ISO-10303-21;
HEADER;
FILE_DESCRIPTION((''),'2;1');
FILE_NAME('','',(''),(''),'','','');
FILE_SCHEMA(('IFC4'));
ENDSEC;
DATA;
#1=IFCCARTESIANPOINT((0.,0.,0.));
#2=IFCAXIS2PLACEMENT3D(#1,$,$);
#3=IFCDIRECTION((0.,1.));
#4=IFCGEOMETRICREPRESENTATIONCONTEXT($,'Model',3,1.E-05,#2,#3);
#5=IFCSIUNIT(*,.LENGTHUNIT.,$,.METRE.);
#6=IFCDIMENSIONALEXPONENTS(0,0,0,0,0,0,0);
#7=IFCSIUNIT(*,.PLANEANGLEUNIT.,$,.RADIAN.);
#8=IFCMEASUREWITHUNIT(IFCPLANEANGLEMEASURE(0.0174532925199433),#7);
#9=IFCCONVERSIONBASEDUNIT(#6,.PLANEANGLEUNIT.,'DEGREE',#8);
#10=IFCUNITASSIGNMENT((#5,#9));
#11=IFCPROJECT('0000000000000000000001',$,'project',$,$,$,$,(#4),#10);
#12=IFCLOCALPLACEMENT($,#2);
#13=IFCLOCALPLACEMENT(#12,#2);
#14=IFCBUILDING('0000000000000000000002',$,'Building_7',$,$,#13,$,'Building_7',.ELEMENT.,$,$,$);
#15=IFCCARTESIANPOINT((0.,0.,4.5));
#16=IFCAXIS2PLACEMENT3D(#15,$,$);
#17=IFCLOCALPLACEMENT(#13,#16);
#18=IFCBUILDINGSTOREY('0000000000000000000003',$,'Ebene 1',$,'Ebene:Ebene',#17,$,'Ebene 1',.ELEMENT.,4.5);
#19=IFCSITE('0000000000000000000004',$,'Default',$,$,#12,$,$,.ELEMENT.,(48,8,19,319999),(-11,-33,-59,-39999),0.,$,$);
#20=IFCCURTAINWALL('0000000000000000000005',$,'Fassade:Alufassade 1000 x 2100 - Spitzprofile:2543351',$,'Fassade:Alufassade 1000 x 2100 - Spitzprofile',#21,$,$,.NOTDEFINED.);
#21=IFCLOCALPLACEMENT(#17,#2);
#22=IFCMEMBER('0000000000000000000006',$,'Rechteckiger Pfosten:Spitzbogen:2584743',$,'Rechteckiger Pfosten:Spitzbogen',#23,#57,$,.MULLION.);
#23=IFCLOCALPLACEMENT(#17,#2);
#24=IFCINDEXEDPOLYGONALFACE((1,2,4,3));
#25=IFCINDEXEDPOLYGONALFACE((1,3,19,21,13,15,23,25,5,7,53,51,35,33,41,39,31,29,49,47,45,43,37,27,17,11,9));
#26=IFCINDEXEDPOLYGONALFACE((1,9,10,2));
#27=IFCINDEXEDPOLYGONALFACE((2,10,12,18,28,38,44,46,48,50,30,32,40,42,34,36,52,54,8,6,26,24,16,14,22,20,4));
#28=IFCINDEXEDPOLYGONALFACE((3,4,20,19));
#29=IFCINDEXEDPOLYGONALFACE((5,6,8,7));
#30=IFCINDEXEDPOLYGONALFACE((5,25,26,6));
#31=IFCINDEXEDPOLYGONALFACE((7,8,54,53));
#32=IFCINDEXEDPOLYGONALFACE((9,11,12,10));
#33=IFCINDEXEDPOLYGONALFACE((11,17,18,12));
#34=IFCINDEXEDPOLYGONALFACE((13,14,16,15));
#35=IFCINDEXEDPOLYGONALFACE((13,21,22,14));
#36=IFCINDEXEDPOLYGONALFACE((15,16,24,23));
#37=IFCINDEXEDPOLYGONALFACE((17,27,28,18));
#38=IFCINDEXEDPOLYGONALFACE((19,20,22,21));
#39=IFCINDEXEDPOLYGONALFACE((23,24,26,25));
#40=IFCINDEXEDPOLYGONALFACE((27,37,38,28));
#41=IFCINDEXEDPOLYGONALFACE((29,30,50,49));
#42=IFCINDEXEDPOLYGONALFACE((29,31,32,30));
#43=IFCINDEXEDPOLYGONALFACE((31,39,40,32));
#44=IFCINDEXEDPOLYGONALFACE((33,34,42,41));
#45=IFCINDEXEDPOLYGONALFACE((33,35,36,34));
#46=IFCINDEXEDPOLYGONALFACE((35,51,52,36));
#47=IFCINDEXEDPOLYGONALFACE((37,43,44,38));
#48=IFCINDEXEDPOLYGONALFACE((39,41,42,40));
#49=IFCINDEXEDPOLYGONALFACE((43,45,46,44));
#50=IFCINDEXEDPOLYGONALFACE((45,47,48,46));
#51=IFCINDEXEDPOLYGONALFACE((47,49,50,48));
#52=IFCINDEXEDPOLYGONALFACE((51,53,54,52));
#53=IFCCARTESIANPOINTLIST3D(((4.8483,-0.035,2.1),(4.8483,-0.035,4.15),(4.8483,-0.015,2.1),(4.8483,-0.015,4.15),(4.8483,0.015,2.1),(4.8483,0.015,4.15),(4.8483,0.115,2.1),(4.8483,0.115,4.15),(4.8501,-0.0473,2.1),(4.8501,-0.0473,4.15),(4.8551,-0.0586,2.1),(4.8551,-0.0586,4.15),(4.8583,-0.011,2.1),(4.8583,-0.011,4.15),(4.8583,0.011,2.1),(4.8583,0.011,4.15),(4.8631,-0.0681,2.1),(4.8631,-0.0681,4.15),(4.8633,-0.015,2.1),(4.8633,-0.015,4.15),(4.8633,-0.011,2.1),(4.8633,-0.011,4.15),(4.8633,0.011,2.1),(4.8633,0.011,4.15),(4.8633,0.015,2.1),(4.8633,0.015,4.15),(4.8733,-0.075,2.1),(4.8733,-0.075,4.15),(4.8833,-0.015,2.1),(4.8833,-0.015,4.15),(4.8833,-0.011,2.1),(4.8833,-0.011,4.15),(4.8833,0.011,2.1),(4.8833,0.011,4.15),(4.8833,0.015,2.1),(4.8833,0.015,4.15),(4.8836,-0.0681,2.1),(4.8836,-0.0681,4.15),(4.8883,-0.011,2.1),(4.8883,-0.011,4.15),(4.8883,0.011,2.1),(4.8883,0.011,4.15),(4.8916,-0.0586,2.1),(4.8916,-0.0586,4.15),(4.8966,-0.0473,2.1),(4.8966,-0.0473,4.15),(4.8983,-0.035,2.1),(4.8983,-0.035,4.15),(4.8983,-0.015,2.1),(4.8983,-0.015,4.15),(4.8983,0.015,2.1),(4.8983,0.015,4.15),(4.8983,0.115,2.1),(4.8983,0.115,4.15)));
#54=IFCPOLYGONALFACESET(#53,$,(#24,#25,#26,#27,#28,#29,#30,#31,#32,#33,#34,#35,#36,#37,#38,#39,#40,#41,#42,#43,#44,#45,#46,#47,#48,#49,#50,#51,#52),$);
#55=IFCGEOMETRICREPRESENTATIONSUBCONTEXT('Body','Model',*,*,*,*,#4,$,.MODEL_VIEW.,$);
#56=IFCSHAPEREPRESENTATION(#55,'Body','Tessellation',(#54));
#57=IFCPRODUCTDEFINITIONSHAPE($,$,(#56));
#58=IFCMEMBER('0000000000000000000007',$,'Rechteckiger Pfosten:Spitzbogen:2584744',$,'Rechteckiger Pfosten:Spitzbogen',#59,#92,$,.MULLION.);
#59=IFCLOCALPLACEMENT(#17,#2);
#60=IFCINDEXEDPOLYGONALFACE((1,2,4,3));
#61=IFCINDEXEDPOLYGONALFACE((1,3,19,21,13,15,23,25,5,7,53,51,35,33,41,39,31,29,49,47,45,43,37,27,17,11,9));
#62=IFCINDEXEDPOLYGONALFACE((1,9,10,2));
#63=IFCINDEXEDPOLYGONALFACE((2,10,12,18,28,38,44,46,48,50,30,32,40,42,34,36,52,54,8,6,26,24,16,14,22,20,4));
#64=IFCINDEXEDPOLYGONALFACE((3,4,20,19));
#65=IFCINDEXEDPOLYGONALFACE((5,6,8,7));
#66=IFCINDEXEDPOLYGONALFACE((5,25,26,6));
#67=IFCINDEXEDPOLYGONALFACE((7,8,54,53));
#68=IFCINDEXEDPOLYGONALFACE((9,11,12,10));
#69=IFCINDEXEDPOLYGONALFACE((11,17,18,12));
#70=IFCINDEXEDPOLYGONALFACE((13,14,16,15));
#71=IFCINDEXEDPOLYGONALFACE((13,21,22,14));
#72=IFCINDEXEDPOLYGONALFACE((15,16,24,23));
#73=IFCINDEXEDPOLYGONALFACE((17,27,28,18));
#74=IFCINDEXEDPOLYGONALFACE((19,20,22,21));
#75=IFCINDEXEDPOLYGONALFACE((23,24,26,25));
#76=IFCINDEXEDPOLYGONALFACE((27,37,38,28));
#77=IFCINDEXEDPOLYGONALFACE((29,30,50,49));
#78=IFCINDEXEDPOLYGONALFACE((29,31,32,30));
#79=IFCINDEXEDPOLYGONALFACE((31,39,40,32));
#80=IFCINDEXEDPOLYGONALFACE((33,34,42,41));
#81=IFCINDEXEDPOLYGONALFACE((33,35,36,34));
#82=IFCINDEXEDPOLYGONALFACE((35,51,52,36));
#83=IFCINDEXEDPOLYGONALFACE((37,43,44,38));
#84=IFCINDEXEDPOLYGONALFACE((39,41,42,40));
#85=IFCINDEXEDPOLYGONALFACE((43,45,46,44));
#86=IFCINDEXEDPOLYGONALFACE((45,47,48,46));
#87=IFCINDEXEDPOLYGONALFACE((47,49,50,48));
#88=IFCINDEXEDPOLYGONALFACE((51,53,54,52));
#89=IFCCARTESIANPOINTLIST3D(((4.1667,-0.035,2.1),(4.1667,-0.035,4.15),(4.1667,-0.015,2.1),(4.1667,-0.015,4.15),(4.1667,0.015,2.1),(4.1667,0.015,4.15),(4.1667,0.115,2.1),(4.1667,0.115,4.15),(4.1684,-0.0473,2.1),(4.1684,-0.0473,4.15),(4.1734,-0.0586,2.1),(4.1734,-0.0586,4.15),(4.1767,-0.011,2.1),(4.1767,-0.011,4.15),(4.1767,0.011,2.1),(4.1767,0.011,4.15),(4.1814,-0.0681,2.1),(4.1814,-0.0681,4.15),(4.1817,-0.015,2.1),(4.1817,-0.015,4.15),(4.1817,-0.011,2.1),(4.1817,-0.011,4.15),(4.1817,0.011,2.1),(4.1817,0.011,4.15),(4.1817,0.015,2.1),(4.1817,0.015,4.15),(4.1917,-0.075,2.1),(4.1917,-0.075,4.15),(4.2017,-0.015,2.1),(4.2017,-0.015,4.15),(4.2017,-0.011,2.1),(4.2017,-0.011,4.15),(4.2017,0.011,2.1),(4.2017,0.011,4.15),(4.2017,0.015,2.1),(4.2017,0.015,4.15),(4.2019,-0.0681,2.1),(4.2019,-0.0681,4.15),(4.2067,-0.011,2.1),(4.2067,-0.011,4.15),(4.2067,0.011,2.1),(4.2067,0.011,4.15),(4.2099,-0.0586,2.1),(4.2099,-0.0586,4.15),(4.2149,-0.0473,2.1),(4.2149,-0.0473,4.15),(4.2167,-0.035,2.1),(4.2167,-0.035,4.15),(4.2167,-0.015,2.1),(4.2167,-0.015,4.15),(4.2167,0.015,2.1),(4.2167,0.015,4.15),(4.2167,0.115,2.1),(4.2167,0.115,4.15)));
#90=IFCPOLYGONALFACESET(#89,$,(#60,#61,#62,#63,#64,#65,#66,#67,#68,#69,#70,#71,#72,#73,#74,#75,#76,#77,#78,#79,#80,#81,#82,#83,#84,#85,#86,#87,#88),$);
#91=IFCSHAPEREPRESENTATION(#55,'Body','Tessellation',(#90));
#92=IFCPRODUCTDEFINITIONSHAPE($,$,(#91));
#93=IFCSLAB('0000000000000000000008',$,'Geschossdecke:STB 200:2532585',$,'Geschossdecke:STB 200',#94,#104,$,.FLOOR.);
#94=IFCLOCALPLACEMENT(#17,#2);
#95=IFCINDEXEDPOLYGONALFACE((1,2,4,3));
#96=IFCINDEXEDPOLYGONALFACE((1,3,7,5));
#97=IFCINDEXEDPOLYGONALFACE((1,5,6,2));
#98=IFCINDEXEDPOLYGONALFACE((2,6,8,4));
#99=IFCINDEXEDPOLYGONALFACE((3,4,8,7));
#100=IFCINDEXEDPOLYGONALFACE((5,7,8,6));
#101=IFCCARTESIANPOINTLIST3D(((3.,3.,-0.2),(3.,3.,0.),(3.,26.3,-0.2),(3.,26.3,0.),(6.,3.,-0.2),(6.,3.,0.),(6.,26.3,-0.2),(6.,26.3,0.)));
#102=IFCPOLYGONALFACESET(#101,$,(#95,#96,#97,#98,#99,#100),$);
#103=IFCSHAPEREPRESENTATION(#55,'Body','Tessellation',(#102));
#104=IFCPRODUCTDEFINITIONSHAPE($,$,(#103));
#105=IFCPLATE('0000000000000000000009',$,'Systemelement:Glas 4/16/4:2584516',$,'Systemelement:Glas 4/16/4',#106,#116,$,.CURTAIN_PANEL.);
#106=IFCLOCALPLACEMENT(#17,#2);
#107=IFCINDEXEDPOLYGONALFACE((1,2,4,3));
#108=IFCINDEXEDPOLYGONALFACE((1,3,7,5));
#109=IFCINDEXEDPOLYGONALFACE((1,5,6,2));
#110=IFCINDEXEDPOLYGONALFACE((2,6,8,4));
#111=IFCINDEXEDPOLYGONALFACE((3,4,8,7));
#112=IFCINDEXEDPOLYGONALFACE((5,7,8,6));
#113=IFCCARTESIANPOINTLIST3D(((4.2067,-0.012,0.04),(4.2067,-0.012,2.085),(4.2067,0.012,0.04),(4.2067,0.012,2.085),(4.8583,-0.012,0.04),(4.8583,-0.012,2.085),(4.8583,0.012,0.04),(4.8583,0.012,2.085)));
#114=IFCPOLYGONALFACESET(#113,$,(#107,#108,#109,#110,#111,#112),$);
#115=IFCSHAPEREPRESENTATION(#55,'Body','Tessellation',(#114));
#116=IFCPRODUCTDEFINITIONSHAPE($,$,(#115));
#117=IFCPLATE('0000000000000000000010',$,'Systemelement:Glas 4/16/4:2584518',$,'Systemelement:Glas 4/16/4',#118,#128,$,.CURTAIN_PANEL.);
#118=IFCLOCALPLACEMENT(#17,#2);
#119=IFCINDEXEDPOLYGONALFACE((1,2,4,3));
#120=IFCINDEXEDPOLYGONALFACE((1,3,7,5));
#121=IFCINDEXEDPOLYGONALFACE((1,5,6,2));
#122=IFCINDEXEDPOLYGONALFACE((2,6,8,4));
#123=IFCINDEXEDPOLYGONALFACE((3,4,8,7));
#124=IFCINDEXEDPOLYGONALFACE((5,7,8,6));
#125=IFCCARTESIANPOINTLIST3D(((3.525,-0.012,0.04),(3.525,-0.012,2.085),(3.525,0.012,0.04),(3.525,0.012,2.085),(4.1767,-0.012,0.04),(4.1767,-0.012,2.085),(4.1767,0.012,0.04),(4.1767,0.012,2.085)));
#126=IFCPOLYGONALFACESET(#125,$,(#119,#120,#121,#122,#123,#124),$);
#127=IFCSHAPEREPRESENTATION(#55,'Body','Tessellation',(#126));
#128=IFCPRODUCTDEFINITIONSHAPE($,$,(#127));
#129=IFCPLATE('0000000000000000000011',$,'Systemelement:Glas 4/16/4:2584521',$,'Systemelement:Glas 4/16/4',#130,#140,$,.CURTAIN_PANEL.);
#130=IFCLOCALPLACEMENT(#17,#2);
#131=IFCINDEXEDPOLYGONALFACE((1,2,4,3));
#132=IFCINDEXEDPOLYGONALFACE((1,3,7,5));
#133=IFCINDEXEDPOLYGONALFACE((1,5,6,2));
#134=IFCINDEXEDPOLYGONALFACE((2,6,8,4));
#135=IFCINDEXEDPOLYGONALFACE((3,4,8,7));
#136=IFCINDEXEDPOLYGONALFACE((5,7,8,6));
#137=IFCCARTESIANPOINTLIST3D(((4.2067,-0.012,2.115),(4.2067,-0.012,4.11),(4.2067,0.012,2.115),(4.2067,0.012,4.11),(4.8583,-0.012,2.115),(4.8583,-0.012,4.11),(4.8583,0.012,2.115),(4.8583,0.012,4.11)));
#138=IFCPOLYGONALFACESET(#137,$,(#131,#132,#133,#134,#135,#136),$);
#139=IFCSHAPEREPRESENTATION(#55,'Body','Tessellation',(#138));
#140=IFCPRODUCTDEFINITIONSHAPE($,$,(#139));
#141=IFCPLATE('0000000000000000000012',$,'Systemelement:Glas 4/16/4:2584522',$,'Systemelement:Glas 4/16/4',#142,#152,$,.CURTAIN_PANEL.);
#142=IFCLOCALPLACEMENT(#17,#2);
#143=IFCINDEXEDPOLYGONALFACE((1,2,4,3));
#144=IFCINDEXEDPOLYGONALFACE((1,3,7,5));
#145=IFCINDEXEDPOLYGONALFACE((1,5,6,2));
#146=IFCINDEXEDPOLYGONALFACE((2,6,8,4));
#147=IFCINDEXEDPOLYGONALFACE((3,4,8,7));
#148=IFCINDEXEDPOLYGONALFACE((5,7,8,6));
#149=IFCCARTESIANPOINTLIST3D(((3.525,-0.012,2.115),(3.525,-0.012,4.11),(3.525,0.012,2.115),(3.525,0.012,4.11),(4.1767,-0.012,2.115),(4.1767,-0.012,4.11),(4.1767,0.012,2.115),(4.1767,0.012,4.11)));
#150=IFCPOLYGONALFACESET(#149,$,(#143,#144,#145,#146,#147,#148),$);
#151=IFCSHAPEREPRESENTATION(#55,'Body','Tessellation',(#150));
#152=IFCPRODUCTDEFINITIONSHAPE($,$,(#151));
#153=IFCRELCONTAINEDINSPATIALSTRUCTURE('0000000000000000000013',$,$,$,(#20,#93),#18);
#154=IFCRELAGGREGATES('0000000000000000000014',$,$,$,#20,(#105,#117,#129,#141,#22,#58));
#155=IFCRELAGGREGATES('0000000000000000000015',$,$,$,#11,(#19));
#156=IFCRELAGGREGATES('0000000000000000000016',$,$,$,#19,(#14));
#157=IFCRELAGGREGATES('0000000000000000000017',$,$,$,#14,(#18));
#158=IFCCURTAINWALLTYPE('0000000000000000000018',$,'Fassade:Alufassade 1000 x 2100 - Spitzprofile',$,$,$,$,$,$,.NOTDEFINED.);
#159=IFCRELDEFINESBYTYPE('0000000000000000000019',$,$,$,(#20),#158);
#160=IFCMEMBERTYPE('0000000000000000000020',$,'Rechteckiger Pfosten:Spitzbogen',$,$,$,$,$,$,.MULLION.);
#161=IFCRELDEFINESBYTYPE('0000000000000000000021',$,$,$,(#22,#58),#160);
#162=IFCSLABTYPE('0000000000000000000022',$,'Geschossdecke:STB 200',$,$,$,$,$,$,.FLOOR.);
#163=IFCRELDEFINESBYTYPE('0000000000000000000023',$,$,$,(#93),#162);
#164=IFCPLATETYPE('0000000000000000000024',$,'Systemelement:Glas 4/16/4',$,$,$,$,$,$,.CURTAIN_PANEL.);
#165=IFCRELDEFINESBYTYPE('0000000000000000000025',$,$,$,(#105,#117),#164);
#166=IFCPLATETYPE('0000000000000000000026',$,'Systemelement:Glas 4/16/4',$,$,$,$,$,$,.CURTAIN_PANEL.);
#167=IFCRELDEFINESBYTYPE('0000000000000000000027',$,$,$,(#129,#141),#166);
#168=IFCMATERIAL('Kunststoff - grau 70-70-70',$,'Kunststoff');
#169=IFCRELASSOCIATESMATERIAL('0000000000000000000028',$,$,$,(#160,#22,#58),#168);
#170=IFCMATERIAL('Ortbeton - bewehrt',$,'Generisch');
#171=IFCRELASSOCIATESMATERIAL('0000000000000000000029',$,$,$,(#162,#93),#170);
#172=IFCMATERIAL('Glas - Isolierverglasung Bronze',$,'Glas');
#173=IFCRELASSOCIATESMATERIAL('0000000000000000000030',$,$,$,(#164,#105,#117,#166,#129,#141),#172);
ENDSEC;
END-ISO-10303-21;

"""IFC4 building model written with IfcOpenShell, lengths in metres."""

from ifc_helpers import new_model, entity, si_unit, converted_unit, direction, frame, origin, place, context, subcontext, project, spatial, line, arc, indexed_curve, outline, extrude, source, transform, mapped, material, type_object, type_shapes, element, aggregate, save


model = new_model("IFC4")

# Units and contexts
model_context = context("Model", 3, precision=1e-05, world=origin(), true_north=direction((0.0, 1.0)))
body_context = subcontext(model_context, "Body", "Model", "MODEL_VIEW")
ifc_project = project(units=[si_unit("LENGTHUNIT", "METRE"), converted_unit("PLANEANGLEUNIT", "DEGREE", entity("IfcPlaneAngleMeasure", 0.0174532925199433), si_unit("PLANEANGLEUNIT", "RADIAN"), dimensions=[0, 0, 0, 0, 0, 0, 0])], contexts=[model_context])

# Site, building, storey
site_placement = place(None, origin())
site = spatial("IfcSite", under=ifc_project, at=site_placement, Name="Default", CompositionType="ELEMENT", RefLatitude=(48, 8, 19, 319999), RefLongitude=(-11, -33, -59, -39999), RefElevation=0.0)
building_placement = place(site_placement, origin())
building = spatial("IfcBuilding", under=site, at=building_placement, Name="Building_7", LongName="Building_7", CompositionType="ELEMENT")
storey_placement = place(building_placement, frame((0.0, 0.0, 4.5)))
storey = spatial("IfcBuildingStorey", under=building, at=storey_placement, Name="Ebene 1", ObjectType="Ebene:Ebene", LongName="Ebene 1", CompositionType="ELEMENT", Elevation=4.5)

# Curtain wall, members
curtain_wall_type = type_object("IfcCurtainWallType", Name="Fassade:Alufassade 1000 x 2100 - Spitzprofile", PredefinedType="NOTDEFINED")
curtain_wall_placement = place(storey_placement, frame((0.0, 0.0, -4.5)))
curtain_wall = element("IfcCurtainWall", 1, at=curtain_wall_placement, inside=storey, type_object=curtain_wall_type, Name="Fassade:Alufassade 1000 x 2100 - Spitzprofile:2543351", ObjectType="Fassade:Alufassade 1000 x 2100 - Spitzprofile", PredefinedType="NOTDEFINED")
ifc_material_1 = material(Name="Kunststoff - grau 70-70-70", Category="Kunststoff")
member_type_1 = type_object("IfcMemberType", Name="Rechteckiger Pfosten:Spitzbogen", PredefinedType="MULLION", material=ifc_material_1)
shared_shape_1 = source(origin(), body_context, "Body", "SweptSolid", [
    extrude(outline(indexed_curve([(-0.111, -0.025), (-0.011, -0.025), (-0.011, -0.01), (-0.007, -0.01), (-0.007, -0.015), (0.015, -0.015), (0.015, -0.01), (0.019, -0.01), (0.019, -0.025), (0.039, -0.025), (0.0626, -0.0182), (0.079, 0.0), (0.0626, 0.0182), (0.039, 0.025), (0.019, 0.025), (0.019, 0.01), (0.015, 0.01), (0.015, 0.015), (-0.007, 0.015), (-0.007, 0.01), (-0.011, 0.01), (-0.011, 0.025), (-0.111, 0.025)], segments=[line(1, 2, 3, 4, 5, 6, 7, 8, 9, 10), arc(10, 11, 12), arc(12, 13, 14), line(14, 15, 16, 17, 18, 19, 20, 21, 22, 23, 1)], self_intersect=False)), frame((0.0, 0.004, -2.05), z_axis=(0.0, 0.0, 1.0), x_axis=(0.0, -1.0, 0.0)), (0.0, 0.0, 1.0), 2.05),
])
type_shapes(member_type_1, [shared_shape_1])
member_1_placement = place(curtain_wall_placement, frame((4.8733, 0.0, 6.6), z_axis=(0.0, 0.0, -1.0), x_axis=(-1.0, 0.0, 0.0)))
member_1 = element("IfcMember", 2, at=member_1_placement, type_object=member_type_1, material=ifc_material_1, Name="Rechteckiger Pfosten:Spitzbogen:2584743", ObjectType="Rechteckiger Pfosten:Spitzbogen", PredefinedType="MULLION", context=body_context, shape_type="MappedRepresentation", body=[
    mapped(shared_shape_1, transform((0.0, 0.0, 0.0), scale=1.0)),
])
member_2_placement = place(curtain_wall_placement, frame((4.1917, 0.0, 6.6), z_axis=(0.0, 0.0, -1.0), x_axis=(-1.0, 0.0, 0.0)))
member_2 = element("IfcMember", 3, at=member_2_placement, type_object=member_type_1, material=ifc_material_1, Name="Rechteckiger Pfosten:Spitzbogen:2584744", ObjectType="Rechteckiger Pfosten:Spitzbogen", PredefinedType="MULLION", context=body_context, shape_type="MappedRepresentation", body=[
    mapped(shared_shape_1, transform((0.0, 0.0, 0.0), scale=1.0)),
])

# Slab
ifc_material_2 = material(Name="Ortbeton - bewehrt", Category="Generisch")
slab_type_1 = type_object("IfcSlabType", Name="Geschossdecke:STB 200", PredefinedType="FLOOR", material=ifc_material_2)
slab_1_placement = place(storey_placement, origin())
element("IfcSlab", 4, at=slab_1_placement, inside=storey, type_object=slab_type_1, material=ifc_material_2, Name="Geschossdecke:STB 200:2532585", ObjectType="Geschossdecke:STB 200", PredefinedType="FLOOR", context=body_context, shape_type="SweptSolid", body=[
    extrude(outline(indexed_curve([(-11.65, -1.5), (11.65, -1.5), (11.65, 1.5), (-11.65, 1.5), (-11.65, -1.5)], self_intersect=False)), frame((4.5, 14.65, 0.0), z_axis=(0.0, 0.0, -1.0), x_axis=(0.0, 1.0, 0.0)), (0.0, 0.0, 1.0), 0.2),
])

# Plates
ifc_material_3 = material(Name="Glas - Isolierverglasung Bronze", Category="Glas")
plate_type_1 = type_object("IfcPlateType", Name="Systemelement:Glas 4/16/4", PredefinedType="CURTAIN_PANEL", material=ifc_material_3)
shared_shape_2 = source(origin(), body_context, "Body", "SweptSolid", [
    extrude(outline(indexed_curve([(-0.012, -0.3258), (0.012, -0.3258), (0.012, 0.3258), (-0.012, 0.3258), (-0.012, -0.3258)], self_intersect=False)), frame((0.0, 0.0, 0.0), z_axis=(0.0, 0.0, 1.0), x_axis=(0.0, 1.0, 0.0)), (0.0, 0.0, 1.0), 2.045),
])
type_shapes(plate_type_1, [shared_shape_2])
plate_1_placement = place(curtain_wall_placement, frame((4.5325, 0.0, 4.54), z_axis=(0.0, 0.0, 1.0), x_axis=(-1.0, 0.0, 0.0)))
plate_1 = element("IfcPlate", 5, at=plate_1_placement, type_object=plate_type_1, material=ifc_material_3, Name="Systemelement:Glas 4/16/4:2584516", ObjectType="Systemelement:Glas 4/16/4", PredefinedType="CURTAIN_PANEL", context=body_context, shape_type="MappedRepresentation", body=[
    mapped(shared_shape_2, transform((0.0, 0.0, 0.0), scale=1.0)),
])
plate_2_placement = place(curtain_wall_placement, frame((3.8508, 0.0, 4.54), z_axis=(0.0, 0.0, 1.0), x_axis=(-1.0, 0.0, 0.0)))
plate_2 = element("IfcPlate", 6, at=plate_2_placement, type_object=plate_type_1, material=ifc_material_3, Name="Systemelement:Glas 4/16/4:2584518", ObjectType="Systemelement:Glas 4/16/4", PredefinedType="CURTAIN_PANEL", context=body_context, shape_type="MappedRepresentation", body=[
    mapped(shared_shape_2, transform((0.0, 0.0, 0.0), scale=1.0)),
])
plate_type_2 = type_object("IfcPlateType", Name="Systemelement:Glas 4/16/4", PredefinedType="CURTAIN_PANEL", material=ifc_material_3)
shared_shape_3 = source(origin(), body_context, "Body", "SweptSolid", [
    extrude(outline(indexed_curve([(-0.012, -0.3258), (0.012, -0.3258), (0.012, 0.3258), (-0.012, 0.3258), (-0.012, -0.3258)], self_intersect=False)), frame((0.0, 0.0, 0.0), z_axis=(0.0, 0.0, 1.0), x_axis=(0.0, 1.0, 0.0)), (0.0, 0.0, 1.0), 1.995),
])
type_shapes(plate_type_2, [shared_shape_3])
plate_3_placement = place(curtain_wall_placement, frame((4.5325, 0.0, 6.615), z_axis=(0.0, 0.0, 1.0), x_axis=(-1.0, 0.0, 0.0)))
plate_3 = element("IfcPlate", 7, at=plate_3_placement, type_object=plate_type_2, material=ifc_material_3, Name="Systemelement:Glas 4/16/4:2584521", ObjectType="Systemelement:Glas 4/16/4", PredefinedType="CURTAIN_PANEL", context=body_context, shape_type="MappedRepresentation", body=[
    mapped(shared_shape_3, transform((0.0, 0.0, 0.0), scale=1.0)),
])
plate_4_placement = place(curtain_wall_placement, frame((3.8508, 0.0, 6.615), z_axis=(0.0, 0.0, 1.0), x_axis=(-1.0, 0.0, 0.0)))
plate_4 = element("IfcPlate", 8, at=plate_4_placement, type_object=plate_type_2, material=ifc_material_3, Name="Systemelement:Glas 4/16/4:2584522", ObjectType="Systemelement:Glas 4/16/4", PredefinedType="CURTAIN_PANEL", context=body_context, shape_type="MappedRepresentation", body=[
    mapped(shared_shape_3, transform((0.0, 0.0, 0.0), scale=1.0)),
])
aggregate(curtain_wall, [plate_1, plate_2, plate_3, plate_4, member_1, member_2])

save(model, "model.ifc")
